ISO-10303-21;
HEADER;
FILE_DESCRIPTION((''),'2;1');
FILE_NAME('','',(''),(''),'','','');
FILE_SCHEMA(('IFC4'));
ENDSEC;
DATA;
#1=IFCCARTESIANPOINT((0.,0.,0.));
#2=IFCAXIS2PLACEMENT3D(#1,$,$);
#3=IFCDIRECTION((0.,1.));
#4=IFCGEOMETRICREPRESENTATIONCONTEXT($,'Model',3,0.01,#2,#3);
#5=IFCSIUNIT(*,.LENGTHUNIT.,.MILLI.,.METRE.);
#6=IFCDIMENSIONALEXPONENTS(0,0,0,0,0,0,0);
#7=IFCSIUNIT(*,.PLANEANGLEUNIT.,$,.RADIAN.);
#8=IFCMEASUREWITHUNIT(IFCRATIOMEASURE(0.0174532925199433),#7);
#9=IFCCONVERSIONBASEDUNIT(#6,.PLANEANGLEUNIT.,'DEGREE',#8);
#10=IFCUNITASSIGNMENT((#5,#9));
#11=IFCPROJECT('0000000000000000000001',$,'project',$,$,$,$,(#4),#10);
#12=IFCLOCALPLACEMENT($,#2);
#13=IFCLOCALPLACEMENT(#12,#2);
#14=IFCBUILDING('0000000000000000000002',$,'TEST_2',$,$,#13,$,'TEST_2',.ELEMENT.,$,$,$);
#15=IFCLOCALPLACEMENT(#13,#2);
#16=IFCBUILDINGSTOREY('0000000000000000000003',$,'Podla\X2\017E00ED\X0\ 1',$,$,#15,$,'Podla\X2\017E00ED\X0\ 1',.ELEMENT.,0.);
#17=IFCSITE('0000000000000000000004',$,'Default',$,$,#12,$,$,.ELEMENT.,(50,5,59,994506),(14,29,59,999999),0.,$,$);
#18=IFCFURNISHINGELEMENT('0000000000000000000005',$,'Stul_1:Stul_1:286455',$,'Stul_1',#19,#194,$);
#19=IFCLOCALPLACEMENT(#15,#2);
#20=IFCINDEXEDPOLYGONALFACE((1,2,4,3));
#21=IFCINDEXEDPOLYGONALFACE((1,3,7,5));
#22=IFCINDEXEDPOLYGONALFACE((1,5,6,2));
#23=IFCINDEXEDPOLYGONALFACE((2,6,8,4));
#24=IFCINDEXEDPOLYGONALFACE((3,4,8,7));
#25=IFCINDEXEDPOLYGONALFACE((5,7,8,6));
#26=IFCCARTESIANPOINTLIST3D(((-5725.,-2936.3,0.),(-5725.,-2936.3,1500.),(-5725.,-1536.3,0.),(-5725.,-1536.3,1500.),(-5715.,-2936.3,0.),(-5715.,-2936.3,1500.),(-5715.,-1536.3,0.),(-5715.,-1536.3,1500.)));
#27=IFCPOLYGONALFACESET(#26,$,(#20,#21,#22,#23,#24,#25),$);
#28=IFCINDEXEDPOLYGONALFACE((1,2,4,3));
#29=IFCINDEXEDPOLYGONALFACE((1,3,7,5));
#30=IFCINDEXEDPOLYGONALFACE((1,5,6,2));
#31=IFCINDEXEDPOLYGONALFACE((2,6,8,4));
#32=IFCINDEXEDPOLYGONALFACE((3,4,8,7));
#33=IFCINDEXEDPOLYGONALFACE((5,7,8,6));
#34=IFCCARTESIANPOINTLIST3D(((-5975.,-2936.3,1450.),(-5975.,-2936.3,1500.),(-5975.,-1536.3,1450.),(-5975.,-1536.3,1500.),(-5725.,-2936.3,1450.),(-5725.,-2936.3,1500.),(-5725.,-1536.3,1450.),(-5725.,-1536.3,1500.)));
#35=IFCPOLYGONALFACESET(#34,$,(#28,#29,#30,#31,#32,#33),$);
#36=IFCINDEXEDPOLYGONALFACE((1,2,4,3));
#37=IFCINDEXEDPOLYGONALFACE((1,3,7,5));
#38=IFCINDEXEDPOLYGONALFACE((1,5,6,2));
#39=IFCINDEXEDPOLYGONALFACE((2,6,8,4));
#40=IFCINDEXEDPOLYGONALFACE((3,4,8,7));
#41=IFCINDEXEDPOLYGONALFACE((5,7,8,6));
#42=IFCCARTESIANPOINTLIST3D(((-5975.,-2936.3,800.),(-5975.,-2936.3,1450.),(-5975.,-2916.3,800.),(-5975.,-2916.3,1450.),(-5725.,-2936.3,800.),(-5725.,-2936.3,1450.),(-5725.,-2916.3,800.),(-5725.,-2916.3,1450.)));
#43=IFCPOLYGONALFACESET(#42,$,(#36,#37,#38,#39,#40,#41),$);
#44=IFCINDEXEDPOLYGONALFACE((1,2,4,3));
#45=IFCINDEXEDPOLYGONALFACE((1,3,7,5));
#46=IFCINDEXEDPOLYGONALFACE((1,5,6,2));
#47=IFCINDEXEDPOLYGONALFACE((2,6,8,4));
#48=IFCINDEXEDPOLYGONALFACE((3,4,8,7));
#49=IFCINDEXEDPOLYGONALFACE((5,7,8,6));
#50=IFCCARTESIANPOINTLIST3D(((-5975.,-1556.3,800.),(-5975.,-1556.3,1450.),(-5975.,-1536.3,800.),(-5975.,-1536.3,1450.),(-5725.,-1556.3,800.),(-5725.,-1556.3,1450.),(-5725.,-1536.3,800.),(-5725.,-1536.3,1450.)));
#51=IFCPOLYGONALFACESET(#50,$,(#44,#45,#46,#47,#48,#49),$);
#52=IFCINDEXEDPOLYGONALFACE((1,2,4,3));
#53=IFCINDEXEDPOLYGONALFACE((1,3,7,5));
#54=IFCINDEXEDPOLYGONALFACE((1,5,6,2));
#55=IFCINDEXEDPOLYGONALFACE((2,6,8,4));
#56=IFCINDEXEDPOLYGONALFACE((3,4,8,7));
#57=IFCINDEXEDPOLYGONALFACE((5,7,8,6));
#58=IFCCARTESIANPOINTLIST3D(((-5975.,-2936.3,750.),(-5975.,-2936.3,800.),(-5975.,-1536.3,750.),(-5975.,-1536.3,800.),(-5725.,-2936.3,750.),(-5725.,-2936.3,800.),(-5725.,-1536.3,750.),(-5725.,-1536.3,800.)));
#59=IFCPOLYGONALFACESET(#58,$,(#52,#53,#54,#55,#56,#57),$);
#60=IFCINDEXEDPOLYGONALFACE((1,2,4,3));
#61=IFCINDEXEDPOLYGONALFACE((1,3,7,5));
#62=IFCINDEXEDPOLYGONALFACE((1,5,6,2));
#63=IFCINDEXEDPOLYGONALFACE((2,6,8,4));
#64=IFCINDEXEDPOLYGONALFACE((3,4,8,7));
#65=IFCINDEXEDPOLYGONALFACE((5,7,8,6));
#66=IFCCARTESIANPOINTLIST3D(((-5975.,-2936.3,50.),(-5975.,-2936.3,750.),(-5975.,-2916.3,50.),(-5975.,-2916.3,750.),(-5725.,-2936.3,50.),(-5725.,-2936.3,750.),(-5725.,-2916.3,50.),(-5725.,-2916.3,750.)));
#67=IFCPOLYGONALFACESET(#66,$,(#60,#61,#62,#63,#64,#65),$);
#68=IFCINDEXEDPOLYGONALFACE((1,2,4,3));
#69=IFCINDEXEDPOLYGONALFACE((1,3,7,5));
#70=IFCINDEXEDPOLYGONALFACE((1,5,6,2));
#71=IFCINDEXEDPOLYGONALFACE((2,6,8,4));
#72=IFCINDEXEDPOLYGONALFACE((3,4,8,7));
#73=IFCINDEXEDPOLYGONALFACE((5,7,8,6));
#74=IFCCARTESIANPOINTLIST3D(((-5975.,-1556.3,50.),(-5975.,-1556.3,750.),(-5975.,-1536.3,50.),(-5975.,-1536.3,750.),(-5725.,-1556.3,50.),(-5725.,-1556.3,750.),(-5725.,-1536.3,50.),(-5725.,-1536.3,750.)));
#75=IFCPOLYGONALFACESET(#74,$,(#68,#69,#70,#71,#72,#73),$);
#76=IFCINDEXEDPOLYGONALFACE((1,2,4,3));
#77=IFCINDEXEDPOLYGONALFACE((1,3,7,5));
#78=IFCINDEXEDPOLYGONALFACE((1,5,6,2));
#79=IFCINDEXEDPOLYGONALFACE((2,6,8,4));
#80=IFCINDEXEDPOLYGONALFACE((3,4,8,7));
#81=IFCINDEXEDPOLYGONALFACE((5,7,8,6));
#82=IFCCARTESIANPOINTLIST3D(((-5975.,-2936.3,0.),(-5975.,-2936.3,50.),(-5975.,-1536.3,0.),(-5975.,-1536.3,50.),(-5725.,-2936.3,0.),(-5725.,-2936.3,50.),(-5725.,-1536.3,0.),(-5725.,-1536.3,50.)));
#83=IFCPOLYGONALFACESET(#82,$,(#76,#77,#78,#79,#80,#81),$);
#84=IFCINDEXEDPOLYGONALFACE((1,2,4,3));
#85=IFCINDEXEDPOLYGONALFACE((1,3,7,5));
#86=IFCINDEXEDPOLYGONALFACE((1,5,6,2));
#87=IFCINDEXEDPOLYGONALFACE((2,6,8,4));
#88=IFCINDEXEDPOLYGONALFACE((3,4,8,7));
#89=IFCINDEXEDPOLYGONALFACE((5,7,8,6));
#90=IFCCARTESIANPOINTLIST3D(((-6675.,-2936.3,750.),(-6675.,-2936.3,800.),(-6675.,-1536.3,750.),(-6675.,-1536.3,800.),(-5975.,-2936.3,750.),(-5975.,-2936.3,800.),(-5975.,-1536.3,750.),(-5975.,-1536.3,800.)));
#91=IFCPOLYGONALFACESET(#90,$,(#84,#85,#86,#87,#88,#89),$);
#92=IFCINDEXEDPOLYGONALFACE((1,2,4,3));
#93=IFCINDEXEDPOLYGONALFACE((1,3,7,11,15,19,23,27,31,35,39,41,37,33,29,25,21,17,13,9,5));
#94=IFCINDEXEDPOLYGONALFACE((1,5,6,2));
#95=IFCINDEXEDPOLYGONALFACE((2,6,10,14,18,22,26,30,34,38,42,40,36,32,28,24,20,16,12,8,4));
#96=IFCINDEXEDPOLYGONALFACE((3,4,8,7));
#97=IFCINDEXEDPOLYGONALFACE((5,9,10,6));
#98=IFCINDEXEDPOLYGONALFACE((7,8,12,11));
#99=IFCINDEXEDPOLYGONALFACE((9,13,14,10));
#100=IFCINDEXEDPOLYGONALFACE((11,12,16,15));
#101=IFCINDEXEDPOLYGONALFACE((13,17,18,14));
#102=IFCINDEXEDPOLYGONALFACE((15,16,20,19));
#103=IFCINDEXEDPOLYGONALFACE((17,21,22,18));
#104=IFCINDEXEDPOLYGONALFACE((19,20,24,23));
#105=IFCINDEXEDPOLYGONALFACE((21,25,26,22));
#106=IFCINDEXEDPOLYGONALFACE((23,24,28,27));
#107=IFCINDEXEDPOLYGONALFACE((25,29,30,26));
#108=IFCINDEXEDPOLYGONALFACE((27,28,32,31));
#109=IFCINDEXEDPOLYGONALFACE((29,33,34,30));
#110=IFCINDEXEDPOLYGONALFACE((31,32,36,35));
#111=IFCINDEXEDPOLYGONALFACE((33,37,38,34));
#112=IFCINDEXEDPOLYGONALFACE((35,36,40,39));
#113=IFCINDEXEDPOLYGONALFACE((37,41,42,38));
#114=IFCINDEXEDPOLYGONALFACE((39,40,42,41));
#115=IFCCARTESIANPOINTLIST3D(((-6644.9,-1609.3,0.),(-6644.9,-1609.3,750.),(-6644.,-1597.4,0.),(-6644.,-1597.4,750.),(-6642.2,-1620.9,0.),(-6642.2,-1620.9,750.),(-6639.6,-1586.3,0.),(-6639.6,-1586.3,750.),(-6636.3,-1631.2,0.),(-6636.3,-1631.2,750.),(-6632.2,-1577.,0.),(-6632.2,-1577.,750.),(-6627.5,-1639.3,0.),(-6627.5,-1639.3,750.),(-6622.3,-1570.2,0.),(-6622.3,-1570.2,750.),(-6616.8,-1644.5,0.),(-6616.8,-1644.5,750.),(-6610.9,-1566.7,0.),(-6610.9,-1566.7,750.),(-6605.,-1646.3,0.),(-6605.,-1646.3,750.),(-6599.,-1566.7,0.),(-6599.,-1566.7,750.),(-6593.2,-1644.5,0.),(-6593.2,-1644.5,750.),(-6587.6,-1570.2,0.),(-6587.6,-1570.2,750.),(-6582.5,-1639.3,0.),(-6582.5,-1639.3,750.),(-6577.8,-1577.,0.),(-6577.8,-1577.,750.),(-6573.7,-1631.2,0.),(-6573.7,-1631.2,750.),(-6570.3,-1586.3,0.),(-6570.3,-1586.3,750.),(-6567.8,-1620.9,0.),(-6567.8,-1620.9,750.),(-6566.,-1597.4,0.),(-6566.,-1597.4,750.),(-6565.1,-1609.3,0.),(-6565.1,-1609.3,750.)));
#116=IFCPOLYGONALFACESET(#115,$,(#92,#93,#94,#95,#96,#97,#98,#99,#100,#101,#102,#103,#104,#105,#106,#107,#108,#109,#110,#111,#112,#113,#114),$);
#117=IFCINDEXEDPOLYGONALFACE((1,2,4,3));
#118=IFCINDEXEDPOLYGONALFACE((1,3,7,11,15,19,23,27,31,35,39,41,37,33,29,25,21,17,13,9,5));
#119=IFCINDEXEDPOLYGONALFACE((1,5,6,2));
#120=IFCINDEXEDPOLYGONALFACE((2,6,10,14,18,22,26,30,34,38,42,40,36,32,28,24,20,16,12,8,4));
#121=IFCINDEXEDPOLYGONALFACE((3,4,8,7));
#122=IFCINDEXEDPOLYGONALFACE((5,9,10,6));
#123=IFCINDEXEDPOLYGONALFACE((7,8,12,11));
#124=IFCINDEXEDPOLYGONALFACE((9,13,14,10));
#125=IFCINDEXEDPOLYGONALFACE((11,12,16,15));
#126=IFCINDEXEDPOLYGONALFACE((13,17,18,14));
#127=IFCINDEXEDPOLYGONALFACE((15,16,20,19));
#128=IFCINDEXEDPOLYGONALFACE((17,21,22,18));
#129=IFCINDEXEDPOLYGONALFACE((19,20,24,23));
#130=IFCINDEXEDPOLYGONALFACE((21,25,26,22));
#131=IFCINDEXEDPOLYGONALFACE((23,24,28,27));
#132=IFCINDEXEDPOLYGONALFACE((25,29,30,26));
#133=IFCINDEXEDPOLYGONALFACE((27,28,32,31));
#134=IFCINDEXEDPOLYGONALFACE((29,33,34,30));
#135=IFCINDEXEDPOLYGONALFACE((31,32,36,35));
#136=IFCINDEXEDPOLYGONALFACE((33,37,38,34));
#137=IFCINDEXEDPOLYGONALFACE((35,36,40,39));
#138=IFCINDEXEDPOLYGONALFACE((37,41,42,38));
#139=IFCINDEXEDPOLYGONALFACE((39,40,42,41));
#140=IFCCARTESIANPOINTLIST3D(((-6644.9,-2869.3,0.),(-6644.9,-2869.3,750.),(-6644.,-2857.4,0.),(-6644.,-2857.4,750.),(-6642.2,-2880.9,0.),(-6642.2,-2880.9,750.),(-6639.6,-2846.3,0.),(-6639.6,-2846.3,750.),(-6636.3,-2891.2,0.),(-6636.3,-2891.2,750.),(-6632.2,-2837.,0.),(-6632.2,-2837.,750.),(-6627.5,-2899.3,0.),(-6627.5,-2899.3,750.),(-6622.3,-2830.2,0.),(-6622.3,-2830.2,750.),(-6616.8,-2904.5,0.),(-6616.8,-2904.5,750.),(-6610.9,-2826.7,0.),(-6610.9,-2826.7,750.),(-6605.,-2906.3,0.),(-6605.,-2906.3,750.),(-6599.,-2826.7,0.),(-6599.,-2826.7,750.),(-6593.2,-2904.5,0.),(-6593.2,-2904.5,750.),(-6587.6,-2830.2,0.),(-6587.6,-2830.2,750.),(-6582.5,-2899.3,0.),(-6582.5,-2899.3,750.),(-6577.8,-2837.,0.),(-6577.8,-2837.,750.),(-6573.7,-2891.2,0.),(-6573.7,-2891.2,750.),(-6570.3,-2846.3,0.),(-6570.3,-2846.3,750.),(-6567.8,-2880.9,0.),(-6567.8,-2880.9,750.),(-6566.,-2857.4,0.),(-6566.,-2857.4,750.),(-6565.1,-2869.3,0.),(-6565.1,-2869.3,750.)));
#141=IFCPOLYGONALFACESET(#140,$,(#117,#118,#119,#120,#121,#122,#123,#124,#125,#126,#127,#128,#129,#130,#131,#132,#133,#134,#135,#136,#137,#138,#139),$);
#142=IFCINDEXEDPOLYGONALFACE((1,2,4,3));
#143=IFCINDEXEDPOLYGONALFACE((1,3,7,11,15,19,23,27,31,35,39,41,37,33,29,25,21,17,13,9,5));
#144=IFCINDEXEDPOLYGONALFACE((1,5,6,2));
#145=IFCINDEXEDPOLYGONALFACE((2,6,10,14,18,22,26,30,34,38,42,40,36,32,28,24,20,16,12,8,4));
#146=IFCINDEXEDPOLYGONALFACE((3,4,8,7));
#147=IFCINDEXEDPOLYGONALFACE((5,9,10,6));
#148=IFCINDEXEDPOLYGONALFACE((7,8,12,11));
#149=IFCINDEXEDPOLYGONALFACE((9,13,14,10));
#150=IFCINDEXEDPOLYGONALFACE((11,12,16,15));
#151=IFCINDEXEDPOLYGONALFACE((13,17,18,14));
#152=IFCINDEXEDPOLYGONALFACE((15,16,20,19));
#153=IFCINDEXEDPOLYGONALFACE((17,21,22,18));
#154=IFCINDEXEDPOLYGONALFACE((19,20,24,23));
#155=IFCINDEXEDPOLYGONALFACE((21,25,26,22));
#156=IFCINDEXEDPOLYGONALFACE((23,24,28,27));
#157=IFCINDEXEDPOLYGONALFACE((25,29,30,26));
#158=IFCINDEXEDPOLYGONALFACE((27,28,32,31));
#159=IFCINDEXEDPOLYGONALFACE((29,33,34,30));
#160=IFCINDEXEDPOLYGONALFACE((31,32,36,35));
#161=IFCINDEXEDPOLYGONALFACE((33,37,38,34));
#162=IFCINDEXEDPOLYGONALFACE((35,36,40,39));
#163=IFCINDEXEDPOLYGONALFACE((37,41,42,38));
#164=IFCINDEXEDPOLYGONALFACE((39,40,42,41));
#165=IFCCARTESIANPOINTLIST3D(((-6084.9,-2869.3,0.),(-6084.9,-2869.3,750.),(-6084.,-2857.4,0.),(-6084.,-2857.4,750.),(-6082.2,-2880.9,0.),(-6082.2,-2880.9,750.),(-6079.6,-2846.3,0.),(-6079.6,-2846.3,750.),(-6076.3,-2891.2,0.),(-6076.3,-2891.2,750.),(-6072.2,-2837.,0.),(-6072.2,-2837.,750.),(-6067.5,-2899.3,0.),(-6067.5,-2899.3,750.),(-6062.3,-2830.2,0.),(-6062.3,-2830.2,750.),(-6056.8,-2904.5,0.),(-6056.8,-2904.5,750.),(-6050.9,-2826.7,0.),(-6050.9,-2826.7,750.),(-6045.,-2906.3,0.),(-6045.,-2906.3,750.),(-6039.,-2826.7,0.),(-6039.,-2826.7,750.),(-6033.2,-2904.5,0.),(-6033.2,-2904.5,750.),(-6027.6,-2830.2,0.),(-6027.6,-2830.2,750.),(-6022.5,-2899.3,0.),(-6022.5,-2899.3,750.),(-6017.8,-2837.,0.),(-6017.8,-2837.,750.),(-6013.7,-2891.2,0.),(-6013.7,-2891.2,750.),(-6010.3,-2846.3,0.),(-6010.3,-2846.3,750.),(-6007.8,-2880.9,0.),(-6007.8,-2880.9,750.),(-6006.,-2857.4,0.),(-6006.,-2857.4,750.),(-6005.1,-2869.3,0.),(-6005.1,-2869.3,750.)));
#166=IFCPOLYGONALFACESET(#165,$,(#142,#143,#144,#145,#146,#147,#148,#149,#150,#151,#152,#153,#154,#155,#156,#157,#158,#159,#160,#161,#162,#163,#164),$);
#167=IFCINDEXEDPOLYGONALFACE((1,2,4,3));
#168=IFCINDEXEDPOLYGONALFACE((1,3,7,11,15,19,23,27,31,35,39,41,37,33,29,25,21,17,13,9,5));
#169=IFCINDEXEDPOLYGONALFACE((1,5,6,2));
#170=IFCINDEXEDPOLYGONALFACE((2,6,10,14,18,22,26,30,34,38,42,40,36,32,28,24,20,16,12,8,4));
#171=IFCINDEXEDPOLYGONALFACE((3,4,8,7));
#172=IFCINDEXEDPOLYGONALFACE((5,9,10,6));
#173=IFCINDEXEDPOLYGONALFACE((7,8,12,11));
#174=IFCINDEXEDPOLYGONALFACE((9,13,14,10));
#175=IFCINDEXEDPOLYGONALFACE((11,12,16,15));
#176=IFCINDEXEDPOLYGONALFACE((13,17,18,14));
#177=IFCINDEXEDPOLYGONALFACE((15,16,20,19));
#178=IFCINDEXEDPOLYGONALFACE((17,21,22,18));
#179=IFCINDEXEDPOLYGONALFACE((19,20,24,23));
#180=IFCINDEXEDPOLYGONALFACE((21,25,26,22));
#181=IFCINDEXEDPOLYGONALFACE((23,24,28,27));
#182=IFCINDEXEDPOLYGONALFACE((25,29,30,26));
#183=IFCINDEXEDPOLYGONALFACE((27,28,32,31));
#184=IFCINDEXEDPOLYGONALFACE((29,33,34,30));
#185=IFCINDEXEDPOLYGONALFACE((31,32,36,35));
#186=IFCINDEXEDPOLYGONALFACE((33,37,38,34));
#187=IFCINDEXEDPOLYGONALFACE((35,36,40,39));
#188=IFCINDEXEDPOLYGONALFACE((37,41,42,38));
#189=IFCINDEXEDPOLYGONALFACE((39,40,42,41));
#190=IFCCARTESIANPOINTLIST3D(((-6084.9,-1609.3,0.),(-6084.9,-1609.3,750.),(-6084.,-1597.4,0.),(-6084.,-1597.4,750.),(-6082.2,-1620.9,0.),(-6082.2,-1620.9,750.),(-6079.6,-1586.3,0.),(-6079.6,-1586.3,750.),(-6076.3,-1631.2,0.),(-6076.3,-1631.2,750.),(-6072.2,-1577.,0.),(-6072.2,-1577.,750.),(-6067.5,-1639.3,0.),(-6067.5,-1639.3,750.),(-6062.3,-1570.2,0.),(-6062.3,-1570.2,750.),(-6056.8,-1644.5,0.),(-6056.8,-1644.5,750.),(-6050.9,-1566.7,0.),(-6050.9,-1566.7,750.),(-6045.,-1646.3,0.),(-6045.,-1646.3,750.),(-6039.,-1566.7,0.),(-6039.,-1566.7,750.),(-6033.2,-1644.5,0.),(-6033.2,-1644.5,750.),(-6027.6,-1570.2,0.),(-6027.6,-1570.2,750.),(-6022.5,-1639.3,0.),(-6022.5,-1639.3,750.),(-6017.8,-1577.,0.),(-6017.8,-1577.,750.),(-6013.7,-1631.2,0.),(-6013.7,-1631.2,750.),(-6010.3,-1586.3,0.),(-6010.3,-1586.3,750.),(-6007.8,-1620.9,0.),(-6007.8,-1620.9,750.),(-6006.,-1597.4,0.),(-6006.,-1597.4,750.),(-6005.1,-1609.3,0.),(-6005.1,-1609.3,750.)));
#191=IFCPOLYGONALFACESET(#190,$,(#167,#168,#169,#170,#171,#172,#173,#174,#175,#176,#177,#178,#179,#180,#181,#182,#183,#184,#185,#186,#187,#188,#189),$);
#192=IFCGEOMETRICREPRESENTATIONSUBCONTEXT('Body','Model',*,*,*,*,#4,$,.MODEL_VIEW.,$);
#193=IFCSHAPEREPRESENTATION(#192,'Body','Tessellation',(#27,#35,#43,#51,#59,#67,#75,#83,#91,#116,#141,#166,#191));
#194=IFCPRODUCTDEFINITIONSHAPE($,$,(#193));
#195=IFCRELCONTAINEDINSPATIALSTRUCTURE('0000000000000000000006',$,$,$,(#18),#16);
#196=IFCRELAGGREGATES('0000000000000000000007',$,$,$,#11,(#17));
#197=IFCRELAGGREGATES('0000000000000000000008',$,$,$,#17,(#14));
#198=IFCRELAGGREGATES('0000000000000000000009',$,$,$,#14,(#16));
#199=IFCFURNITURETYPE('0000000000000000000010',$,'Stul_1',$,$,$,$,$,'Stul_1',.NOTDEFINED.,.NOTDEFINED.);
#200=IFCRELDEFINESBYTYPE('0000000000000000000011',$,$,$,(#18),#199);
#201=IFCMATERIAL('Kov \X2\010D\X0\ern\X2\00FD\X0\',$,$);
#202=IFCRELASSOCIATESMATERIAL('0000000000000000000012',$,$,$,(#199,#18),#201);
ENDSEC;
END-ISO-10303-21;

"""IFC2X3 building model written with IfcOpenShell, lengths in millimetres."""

from ifc_helpers import new_model, entity, si_unit, converted_unit, direction, frame, frame_2d, origin, origin_2d_with_axis, place, context, subcontext, project, spatial, rectangle, circle, extrude, source, transform, mapped, material, type_object, type_shapes, element, save


model = new_model("IFC2X3")

# Units and contexts
model_context = context("Model", 3, precision=0.01, world=origin(), true_north=direction((0.0, 1.0)))
body_context = subcontext(model_context, "Body", "Model", "MODEL_VIEW")
ifc_project = project(units=[si_unit("LENGTHUNIT", "METRE", prefix="MILLI"), converted_unit("PLANEANGLEUNIT", "DEGREE", entity("IfcRatioMeasure", 0.0174532925199433), si_unit("PLANEANGLEUNIT", "RADIAN"), dimensions=[0, 0, 0, 0, 0, 0, 0])], contexts=[model_context])

# Site, building, storey
site_placement = place(None, origin())
site = spatial("IfcSite", under=ifc_project, at=site_placement, Name="Default", CompositionType="ELEMENT", RefLatitude=(50, 5, 59, 994506), RefLongitude=(14, 29, 59, 999999), RefElevation=0.0)
building_placement = place(site_placement, origin())
building = spatial("IfcBuilding", under=site, at=building_placement, Name="TEST_2", LongName="TEST_2", CompositionType="ELEMENT")
storey_placement = place(building_placement, origin())
storey = spatial("IfcBuildingStorey", under=building, at=storey_placement, Name="Podlaží 1", LongName="Podlaží 1", CompositionType="ELEMENT", Elevation=0.0)

# Furnishing element
ifc_material_1 = material(Name="Kov černý")
furniture_type = type_object("IfcFurnitureType", Name="Stul_1", ElementType="Stul_1", material=ifc_material_1)
shared_shape_1 = source(origin(), body_context, "Body", "SweptSolid", [
    extrude(rectangle(XDim=1400.0, YDim=10.0, at=origin_2d_with_axis()), frame((0.0, 605.0, 0.0), z_axis=(0.0, 0.0, 1.0), x_axis=(-1.0, 0.0, 0.0)), (0.0, 0.0, 1.0), 1500.0),
    extrude(rectangle(XDim=1400.0, YDim=250.0, at=frame_2d((0.0, 0.0), x_axis=(1.0, 0.0))), frame((0.0, 475.0, 1450.0), z_axis=(0.0, 0.0, 1.0), x_axis=(-1.0, 0.0, 0.0)), (0.0, 0.0, 1.0), 50.0),
    extrude(rectangle(XDim=20.0, YDim=250.0, at=origin_2d_with_axis()), frame((690.0, 475.0, 800.0), z_axis=(0.0, 0.0, 1.0), x_axis=(-1.0, 0.0, 0.0)), (0.0, 0.0, 1.0), 650.0),
    extrude(rectangle(XDim=20.0, YDim=250.0, at=frame_2d((0.0, 0.0), x_axis=(1.0, 0.0))), frame((-690.0, 475.0, 800.0), z_axis=(0.0, 0.0, 1.0), x_axis=(-1.0, 0.0, 0.0)), (0.0, 0.0, 1.0), 650.0),
    extrude(rectangle(XDim=1400.0, YDim=250.0, at=origin_2d_with_axis()), frame((0.0, 475.0, 750.0), z_axis=(0.0, 0.0, 1.0), x_axis=(-1.0, 0.0, 0.0)), (0.0, 0.0, 1.0), 50.0),
    extrude(rectangle(XDim=20.0, YDim=250.0, at=origin_2d_with_axis()), frame((690.0, 475.0, 50.0), z_axis=(0.0, 0.0, 1.0), x_axis=(-1.0, 0.0, 0.0)), (0.0, 0.0, 1.0), 700.0),
    extrude(rectangle(XDim=20.0, YDim=250.0, at=frame_2d((0.0, 0.0), x_axis=(1.0, 0.0))), frame((-690.0, 475.0, 50.0), z_axis=(0.0, 0.0, 1.0), x_axis=(-1.0, 0.0, 0.0)), (0.0, 0.0, 1.0), 700.0),
    extrude(rectangle(XDim=1400.0, YDim=250.0, at=origin_2d_with_axis()), frame((0.0, 475.0, 0.0), z_axis=(0.0, 0.0, 1.0), x_axis=(-1.0, 0.0, 0.0)), (0.0, 0.0, 1.0), 50.0),
    extrude(rectangle(XDim=1400.0, YDim=700.0, at=origin_2d_with_axis()), frame((0.0, 0.0, 750.0), z_axis=(0.0, 0.0, 1.0), x_axis=(-1.0, 0.0, 0.0)), (0.0, 0.0, 1.0), 50.0),
    extrude(circle(Radius=40.0, at=frame_2d((0.0, 0.0), x_axis=(1.0, 0.0))), frame((-630.0, -280.0, 0.0)), (0.0, 0.0, 1.0), 750.0),
    extrude(circle(Radius=40.0, at=frame_2d((0.0, 0.0), x_axis=(1.0, 0.0))), frame((630.0, -280.0, 0.0)), (0.0, 0.0, 1.0), 750.0),
    extrude(circle(Radius=40.0, at=frame_2d((0.0, 0.0), x_axis=(1.0, 0.0))), frame((630.0, 280.0, 0.0)), (0.0, 0.0, 1.0), 750.0),
    extrude(circle(Radius=40.0, at=frame_2d((0.0, 0.0), x_axis=(1.0, 0.0))), frame((-630.0, 280.0, 0.0)), (0.0, 0.0, 1.0), 750.0),
])
type_shapes(furniture_type, [shared_shape_1])
for number, where, z_axis, x_axis, name in (
    (1, (-6325.0, -2236.3, 0.0), (0.0, 0.0, 1.0), (0.0, -1.0, 0.0), "Stul_1:Stul_1:286455"),
):
    element("IfcFurnishingElement", number, at=place(storey_placement, frame(where, z_axis=z_axis, x_axis=x_axis)), inside=storey, type_object=furniture_type, material=ifc_material_1, Name=name, ObjectType="Stul_1", context=body_context, shape_type="MappedRepresentation", body=[
        mapped(shared_shape_1, transform((0.0, 0.0, 0.0), scale=1.0)),
    ])

save(model, "model.ifc")
